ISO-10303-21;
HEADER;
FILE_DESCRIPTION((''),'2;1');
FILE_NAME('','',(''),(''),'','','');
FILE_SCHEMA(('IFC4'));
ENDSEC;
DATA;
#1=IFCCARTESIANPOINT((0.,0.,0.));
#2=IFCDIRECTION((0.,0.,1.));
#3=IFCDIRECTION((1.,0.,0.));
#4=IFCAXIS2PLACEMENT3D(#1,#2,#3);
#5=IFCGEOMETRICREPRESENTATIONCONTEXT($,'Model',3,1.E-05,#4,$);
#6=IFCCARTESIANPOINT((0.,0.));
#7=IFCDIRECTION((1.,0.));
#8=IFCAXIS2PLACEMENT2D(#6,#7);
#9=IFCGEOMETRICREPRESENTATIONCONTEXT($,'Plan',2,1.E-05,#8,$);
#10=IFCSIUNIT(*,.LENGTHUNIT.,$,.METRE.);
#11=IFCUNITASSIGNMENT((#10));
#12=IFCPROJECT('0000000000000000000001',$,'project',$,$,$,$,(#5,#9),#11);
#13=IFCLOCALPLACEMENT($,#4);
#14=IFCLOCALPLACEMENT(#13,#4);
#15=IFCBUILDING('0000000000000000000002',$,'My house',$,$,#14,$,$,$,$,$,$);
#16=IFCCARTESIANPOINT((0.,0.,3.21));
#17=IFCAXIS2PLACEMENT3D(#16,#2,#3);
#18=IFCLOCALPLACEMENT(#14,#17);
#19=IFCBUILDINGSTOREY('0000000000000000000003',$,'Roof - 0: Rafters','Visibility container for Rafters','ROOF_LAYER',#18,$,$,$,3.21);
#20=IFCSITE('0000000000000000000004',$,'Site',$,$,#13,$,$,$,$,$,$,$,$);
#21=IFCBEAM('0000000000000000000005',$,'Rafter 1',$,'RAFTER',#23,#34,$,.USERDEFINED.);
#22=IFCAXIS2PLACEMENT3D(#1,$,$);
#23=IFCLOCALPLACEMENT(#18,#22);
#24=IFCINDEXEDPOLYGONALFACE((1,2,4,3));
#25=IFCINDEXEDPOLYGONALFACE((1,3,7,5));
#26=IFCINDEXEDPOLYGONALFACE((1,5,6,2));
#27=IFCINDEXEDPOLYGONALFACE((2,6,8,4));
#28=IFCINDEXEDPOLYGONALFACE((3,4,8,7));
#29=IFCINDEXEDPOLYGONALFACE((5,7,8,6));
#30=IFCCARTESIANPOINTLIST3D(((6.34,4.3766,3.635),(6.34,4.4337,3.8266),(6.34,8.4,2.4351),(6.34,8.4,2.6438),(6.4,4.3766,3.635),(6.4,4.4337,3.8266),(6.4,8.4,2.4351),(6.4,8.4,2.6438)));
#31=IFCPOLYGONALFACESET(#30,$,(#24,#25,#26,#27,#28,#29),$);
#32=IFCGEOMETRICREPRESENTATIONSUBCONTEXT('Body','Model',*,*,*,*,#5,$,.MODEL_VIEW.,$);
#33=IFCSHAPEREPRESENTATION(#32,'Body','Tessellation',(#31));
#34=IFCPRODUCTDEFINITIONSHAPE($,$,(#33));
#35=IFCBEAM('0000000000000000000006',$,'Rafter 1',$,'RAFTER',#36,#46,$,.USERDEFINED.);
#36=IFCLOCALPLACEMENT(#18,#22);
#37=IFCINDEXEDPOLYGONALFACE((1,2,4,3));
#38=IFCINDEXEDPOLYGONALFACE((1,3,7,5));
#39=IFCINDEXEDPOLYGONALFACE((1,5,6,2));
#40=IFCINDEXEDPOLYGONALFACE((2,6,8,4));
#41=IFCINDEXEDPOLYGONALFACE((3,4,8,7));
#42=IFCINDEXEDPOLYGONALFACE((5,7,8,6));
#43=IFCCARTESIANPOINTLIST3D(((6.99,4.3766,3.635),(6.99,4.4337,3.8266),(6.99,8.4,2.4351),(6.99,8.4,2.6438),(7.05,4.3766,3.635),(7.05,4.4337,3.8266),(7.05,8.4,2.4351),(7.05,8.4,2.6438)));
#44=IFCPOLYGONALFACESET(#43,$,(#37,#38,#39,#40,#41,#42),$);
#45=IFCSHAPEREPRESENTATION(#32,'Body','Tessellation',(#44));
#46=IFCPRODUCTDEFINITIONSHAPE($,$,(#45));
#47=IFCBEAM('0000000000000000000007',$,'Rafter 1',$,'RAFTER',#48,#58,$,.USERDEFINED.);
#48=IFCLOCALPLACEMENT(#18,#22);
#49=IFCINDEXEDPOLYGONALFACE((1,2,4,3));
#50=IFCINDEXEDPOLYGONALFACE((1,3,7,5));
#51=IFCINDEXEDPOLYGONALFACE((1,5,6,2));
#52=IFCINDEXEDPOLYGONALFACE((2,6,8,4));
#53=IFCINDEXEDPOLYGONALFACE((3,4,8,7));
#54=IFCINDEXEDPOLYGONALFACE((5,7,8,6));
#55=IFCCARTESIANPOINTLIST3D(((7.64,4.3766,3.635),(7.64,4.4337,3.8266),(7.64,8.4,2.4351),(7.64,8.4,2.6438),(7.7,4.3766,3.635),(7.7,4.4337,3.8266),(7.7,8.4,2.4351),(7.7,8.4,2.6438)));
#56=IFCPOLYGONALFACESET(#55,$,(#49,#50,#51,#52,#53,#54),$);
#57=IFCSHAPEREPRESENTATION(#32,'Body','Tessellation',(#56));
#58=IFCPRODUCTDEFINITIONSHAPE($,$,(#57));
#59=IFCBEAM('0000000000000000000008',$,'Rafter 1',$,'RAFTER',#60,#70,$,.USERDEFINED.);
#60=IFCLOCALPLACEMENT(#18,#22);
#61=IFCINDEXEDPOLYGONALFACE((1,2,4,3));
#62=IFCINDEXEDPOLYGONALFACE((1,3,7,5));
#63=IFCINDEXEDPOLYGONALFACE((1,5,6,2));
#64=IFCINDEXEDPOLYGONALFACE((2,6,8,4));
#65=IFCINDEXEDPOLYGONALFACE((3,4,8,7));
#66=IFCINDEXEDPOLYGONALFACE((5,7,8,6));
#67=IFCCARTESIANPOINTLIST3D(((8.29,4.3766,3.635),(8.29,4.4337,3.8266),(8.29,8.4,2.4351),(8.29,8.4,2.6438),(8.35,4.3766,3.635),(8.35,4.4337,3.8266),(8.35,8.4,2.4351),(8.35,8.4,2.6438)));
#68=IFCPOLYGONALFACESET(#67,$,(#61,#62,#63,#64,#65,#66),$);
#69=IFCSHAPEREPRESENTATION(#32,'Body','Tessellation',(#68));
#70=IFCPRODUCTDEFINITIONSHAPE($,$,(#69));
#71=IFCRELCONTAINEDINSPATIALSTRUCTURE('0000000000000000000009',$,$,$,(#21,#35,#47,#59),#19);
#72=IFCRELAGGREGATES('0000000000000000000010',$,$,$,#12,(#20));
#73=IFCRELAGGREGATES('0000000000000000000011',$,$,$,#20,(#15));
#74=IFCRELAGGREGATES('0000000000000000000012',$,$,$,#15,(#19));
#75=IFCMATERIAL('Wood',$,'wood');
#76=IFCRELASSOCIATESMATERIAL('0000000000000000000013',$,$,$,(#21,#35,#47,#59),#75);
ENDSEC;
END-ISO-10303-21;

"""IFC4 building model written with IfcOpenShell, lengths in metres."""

from ifc_helpers import new_model, si_unit, frame, origin_with_axes, origin_2d_with_axis, place, context, subcontext, project, spatial, rectangle, extrude, clip, halfspace, material, element, save


model = new_model("IFC4")

# Units and contexts
model_context = context("Model", 3, precision=1e-05, world=origin_with_axes())
plan_context = context("Plan", 2, precision=1e-05, world=origin_2d_with_axis())
body_context = subcontext(model_context, "Body", "Model", "MODEL_VIEW")
ifc_project = project(units=[si_unit("LENGTHUNIT", "METRE")], contexts=[model_context, plan_context])

# Site, building, storey
site_placement = place(None, origin_with_axes())
site = spatial("IfcSite", under=ifc_project, at=site_placement, Name="Site")
building_placement = place(site_placement, origin_with_axes())
building = spatial("IfcBuilding", under=site, at=building_placement, Name="My house")
storey_placement = place(building_placement, frame((0.0, 0.0, 3.21), z_axis=(0.0, 0.0, 1.0), x_axis=(1.0, 0.0, 0.0)))
storey = spatial("IfcBuildingStorey", under=building, at=storey_placement, Name="Roof - 0: Rafters", Description="Visibility container for Rafters", ObjectType="ROOF_LAYER", Elevation=3.21)

# Beams
ifc_material = material(Name="Wood", Category="wood")
beam_1_placement = place(storey_placement, frame((6.37, 4.4051, 3.7308), z_axis=(0.0, 0.28578, 0.958295), x_axis=(0.0, 0.958295, -0.28578)))
element("IfcBeam", 1, at=beam_1_placement, inside=storey, material=ifc_material, Name="Rafter 1", ObjectType="RAFTER", PredefinedType="USERDEFINED", context=body_context, shape_type="Clipping", body=[
    clip(clip(extrude(rectangle(XDim=0.06, YDim=0.2), frame((0.0, 0.0, 0.0), z_axis=(1.0, 0.0, 0.0), x_axis=(0.0, 1.0, 0.0)), (0.0, 0.0, 1.0), 5.5), halfspace(frame((1.5953, 6.37, -6.7671), z_axis=(-0.958295, 0.0, -0.28578), x_axis=(0.0, 1.0, 0.0)), False)), halfspace(frame((5.8118, 6.37, -5.5097), z_axis=(0.958295, 0.0, 0.28578), x_axis=(0.0, -1.0, 0.0)), False)),
])
beam_2_placement = place(storey_placement, frame((7.02, 4.4051, 3.7308), z_axis=(0.0, 0.28578, 0.958295), x_axis=(0.0, 0.958295, -0.28578)))
element("IfcBeam", 2, at=beam_2_placement, inside=storey, material=ifc_material, Name="Rafter 1", ObjectType="RAFTER", PredefinedType="USERDEFINED", context=body_context, shape_type="Clipping", body=[
    clip(clip(extrude(rectangle(XDim=0.06, YDim=0.2), frame((0.0, 0.0, 0.0), z_axis=(1.0, 0.0, 0.0), x_axis=(0.0, 1.0, 0.0)), (0.0, 0.0, 1.0), 5.5), halfspace(frame((1.5953, 7.02, -6.7671), z_axis=(-0.958295, 0.0, -0.28578), x_axis=(0.0, 1.0, 0.0)), False)), halfspace(frame((5.8118, 7.02, -5.5097), z_axis=(0.958295, 0.0, 0.28578), x_axis=(0.0, -1.0, 0.0)), False)),
])
beam_3_placement = place(storey_placement, frame((7.67, 4.4051, 3.7308), z_axis=(0.0, 0.28578, 0.958295), x_axis=(0.0, 0.958295, -0.28578)))
element("IfcBeam", 3, at=beam_3_placement, inside=storey, material=ifc_material, Name="Rafter 1", ObjectType="RAFTER", PredefinedType="USERDEFINED", context=body_context, shape_type="Clipping", body=[
    clip(clip(extrude(rectangle(XDim=0.06, YDim=0.2), frame((0.0, 0.0, 0.0), z_axis=(1.0, 0.0, 0.0), x_axis=(0.0, 1.0, 0.0)), (0.0, 0.0, 1.0), 5.5), halfspace(frame((1.5953, 7.67, -6.7671), z_axis=(-0.958295, 0.0, -0.28578), x_axis=(0.0, 1.0, 0.0)), False)), halfspace(frame((5.8118, 7.67, -5.5097), z_axis=(0.958295, 0.0, 0.28578), x_axis=(0.0, -1.0, 0.0)), False)),
])
beam_4_placement = place(storey_placement, frame((8.32, 4.4051, 3.7308), z_axis=(0.0, 0.28578, 0.958295), x_axis=(0.0, 0.958295, -0.28578)))
element("IfcBeam", 4, at=beam_4_placement, inside=storey, material=ifc_material, Name="Rafter 1", ObjectType="RAFTER", PredefinedType="USERDEFINED", context=body_context, shape_type="Clipping", body=[
    clip(clip(extrude(rectangle(XDim=0.06, YDim=0.2), frame((0.0, 0.0, 0.0), z_axis=(1.0, 0.0, 0.0), x_axis=(0.0, 1.0, 0.0)), (0.0, 0.0, 1.0), 5.5), halfspace(frame((1.5953, 8.32, -6.7671), z_axis=(-0.958295, 0.0, -0.28578), x_axis=(0.0, 1.0, 0.0)), False)), halfspace(frame((5.8118, 8.32, -5.5097), z_axis=(0.958295, 0.0, 0.28578), x_axis=(0.0, -1.0, 0.0)), False)),
])

save(model, "model.ifc")
